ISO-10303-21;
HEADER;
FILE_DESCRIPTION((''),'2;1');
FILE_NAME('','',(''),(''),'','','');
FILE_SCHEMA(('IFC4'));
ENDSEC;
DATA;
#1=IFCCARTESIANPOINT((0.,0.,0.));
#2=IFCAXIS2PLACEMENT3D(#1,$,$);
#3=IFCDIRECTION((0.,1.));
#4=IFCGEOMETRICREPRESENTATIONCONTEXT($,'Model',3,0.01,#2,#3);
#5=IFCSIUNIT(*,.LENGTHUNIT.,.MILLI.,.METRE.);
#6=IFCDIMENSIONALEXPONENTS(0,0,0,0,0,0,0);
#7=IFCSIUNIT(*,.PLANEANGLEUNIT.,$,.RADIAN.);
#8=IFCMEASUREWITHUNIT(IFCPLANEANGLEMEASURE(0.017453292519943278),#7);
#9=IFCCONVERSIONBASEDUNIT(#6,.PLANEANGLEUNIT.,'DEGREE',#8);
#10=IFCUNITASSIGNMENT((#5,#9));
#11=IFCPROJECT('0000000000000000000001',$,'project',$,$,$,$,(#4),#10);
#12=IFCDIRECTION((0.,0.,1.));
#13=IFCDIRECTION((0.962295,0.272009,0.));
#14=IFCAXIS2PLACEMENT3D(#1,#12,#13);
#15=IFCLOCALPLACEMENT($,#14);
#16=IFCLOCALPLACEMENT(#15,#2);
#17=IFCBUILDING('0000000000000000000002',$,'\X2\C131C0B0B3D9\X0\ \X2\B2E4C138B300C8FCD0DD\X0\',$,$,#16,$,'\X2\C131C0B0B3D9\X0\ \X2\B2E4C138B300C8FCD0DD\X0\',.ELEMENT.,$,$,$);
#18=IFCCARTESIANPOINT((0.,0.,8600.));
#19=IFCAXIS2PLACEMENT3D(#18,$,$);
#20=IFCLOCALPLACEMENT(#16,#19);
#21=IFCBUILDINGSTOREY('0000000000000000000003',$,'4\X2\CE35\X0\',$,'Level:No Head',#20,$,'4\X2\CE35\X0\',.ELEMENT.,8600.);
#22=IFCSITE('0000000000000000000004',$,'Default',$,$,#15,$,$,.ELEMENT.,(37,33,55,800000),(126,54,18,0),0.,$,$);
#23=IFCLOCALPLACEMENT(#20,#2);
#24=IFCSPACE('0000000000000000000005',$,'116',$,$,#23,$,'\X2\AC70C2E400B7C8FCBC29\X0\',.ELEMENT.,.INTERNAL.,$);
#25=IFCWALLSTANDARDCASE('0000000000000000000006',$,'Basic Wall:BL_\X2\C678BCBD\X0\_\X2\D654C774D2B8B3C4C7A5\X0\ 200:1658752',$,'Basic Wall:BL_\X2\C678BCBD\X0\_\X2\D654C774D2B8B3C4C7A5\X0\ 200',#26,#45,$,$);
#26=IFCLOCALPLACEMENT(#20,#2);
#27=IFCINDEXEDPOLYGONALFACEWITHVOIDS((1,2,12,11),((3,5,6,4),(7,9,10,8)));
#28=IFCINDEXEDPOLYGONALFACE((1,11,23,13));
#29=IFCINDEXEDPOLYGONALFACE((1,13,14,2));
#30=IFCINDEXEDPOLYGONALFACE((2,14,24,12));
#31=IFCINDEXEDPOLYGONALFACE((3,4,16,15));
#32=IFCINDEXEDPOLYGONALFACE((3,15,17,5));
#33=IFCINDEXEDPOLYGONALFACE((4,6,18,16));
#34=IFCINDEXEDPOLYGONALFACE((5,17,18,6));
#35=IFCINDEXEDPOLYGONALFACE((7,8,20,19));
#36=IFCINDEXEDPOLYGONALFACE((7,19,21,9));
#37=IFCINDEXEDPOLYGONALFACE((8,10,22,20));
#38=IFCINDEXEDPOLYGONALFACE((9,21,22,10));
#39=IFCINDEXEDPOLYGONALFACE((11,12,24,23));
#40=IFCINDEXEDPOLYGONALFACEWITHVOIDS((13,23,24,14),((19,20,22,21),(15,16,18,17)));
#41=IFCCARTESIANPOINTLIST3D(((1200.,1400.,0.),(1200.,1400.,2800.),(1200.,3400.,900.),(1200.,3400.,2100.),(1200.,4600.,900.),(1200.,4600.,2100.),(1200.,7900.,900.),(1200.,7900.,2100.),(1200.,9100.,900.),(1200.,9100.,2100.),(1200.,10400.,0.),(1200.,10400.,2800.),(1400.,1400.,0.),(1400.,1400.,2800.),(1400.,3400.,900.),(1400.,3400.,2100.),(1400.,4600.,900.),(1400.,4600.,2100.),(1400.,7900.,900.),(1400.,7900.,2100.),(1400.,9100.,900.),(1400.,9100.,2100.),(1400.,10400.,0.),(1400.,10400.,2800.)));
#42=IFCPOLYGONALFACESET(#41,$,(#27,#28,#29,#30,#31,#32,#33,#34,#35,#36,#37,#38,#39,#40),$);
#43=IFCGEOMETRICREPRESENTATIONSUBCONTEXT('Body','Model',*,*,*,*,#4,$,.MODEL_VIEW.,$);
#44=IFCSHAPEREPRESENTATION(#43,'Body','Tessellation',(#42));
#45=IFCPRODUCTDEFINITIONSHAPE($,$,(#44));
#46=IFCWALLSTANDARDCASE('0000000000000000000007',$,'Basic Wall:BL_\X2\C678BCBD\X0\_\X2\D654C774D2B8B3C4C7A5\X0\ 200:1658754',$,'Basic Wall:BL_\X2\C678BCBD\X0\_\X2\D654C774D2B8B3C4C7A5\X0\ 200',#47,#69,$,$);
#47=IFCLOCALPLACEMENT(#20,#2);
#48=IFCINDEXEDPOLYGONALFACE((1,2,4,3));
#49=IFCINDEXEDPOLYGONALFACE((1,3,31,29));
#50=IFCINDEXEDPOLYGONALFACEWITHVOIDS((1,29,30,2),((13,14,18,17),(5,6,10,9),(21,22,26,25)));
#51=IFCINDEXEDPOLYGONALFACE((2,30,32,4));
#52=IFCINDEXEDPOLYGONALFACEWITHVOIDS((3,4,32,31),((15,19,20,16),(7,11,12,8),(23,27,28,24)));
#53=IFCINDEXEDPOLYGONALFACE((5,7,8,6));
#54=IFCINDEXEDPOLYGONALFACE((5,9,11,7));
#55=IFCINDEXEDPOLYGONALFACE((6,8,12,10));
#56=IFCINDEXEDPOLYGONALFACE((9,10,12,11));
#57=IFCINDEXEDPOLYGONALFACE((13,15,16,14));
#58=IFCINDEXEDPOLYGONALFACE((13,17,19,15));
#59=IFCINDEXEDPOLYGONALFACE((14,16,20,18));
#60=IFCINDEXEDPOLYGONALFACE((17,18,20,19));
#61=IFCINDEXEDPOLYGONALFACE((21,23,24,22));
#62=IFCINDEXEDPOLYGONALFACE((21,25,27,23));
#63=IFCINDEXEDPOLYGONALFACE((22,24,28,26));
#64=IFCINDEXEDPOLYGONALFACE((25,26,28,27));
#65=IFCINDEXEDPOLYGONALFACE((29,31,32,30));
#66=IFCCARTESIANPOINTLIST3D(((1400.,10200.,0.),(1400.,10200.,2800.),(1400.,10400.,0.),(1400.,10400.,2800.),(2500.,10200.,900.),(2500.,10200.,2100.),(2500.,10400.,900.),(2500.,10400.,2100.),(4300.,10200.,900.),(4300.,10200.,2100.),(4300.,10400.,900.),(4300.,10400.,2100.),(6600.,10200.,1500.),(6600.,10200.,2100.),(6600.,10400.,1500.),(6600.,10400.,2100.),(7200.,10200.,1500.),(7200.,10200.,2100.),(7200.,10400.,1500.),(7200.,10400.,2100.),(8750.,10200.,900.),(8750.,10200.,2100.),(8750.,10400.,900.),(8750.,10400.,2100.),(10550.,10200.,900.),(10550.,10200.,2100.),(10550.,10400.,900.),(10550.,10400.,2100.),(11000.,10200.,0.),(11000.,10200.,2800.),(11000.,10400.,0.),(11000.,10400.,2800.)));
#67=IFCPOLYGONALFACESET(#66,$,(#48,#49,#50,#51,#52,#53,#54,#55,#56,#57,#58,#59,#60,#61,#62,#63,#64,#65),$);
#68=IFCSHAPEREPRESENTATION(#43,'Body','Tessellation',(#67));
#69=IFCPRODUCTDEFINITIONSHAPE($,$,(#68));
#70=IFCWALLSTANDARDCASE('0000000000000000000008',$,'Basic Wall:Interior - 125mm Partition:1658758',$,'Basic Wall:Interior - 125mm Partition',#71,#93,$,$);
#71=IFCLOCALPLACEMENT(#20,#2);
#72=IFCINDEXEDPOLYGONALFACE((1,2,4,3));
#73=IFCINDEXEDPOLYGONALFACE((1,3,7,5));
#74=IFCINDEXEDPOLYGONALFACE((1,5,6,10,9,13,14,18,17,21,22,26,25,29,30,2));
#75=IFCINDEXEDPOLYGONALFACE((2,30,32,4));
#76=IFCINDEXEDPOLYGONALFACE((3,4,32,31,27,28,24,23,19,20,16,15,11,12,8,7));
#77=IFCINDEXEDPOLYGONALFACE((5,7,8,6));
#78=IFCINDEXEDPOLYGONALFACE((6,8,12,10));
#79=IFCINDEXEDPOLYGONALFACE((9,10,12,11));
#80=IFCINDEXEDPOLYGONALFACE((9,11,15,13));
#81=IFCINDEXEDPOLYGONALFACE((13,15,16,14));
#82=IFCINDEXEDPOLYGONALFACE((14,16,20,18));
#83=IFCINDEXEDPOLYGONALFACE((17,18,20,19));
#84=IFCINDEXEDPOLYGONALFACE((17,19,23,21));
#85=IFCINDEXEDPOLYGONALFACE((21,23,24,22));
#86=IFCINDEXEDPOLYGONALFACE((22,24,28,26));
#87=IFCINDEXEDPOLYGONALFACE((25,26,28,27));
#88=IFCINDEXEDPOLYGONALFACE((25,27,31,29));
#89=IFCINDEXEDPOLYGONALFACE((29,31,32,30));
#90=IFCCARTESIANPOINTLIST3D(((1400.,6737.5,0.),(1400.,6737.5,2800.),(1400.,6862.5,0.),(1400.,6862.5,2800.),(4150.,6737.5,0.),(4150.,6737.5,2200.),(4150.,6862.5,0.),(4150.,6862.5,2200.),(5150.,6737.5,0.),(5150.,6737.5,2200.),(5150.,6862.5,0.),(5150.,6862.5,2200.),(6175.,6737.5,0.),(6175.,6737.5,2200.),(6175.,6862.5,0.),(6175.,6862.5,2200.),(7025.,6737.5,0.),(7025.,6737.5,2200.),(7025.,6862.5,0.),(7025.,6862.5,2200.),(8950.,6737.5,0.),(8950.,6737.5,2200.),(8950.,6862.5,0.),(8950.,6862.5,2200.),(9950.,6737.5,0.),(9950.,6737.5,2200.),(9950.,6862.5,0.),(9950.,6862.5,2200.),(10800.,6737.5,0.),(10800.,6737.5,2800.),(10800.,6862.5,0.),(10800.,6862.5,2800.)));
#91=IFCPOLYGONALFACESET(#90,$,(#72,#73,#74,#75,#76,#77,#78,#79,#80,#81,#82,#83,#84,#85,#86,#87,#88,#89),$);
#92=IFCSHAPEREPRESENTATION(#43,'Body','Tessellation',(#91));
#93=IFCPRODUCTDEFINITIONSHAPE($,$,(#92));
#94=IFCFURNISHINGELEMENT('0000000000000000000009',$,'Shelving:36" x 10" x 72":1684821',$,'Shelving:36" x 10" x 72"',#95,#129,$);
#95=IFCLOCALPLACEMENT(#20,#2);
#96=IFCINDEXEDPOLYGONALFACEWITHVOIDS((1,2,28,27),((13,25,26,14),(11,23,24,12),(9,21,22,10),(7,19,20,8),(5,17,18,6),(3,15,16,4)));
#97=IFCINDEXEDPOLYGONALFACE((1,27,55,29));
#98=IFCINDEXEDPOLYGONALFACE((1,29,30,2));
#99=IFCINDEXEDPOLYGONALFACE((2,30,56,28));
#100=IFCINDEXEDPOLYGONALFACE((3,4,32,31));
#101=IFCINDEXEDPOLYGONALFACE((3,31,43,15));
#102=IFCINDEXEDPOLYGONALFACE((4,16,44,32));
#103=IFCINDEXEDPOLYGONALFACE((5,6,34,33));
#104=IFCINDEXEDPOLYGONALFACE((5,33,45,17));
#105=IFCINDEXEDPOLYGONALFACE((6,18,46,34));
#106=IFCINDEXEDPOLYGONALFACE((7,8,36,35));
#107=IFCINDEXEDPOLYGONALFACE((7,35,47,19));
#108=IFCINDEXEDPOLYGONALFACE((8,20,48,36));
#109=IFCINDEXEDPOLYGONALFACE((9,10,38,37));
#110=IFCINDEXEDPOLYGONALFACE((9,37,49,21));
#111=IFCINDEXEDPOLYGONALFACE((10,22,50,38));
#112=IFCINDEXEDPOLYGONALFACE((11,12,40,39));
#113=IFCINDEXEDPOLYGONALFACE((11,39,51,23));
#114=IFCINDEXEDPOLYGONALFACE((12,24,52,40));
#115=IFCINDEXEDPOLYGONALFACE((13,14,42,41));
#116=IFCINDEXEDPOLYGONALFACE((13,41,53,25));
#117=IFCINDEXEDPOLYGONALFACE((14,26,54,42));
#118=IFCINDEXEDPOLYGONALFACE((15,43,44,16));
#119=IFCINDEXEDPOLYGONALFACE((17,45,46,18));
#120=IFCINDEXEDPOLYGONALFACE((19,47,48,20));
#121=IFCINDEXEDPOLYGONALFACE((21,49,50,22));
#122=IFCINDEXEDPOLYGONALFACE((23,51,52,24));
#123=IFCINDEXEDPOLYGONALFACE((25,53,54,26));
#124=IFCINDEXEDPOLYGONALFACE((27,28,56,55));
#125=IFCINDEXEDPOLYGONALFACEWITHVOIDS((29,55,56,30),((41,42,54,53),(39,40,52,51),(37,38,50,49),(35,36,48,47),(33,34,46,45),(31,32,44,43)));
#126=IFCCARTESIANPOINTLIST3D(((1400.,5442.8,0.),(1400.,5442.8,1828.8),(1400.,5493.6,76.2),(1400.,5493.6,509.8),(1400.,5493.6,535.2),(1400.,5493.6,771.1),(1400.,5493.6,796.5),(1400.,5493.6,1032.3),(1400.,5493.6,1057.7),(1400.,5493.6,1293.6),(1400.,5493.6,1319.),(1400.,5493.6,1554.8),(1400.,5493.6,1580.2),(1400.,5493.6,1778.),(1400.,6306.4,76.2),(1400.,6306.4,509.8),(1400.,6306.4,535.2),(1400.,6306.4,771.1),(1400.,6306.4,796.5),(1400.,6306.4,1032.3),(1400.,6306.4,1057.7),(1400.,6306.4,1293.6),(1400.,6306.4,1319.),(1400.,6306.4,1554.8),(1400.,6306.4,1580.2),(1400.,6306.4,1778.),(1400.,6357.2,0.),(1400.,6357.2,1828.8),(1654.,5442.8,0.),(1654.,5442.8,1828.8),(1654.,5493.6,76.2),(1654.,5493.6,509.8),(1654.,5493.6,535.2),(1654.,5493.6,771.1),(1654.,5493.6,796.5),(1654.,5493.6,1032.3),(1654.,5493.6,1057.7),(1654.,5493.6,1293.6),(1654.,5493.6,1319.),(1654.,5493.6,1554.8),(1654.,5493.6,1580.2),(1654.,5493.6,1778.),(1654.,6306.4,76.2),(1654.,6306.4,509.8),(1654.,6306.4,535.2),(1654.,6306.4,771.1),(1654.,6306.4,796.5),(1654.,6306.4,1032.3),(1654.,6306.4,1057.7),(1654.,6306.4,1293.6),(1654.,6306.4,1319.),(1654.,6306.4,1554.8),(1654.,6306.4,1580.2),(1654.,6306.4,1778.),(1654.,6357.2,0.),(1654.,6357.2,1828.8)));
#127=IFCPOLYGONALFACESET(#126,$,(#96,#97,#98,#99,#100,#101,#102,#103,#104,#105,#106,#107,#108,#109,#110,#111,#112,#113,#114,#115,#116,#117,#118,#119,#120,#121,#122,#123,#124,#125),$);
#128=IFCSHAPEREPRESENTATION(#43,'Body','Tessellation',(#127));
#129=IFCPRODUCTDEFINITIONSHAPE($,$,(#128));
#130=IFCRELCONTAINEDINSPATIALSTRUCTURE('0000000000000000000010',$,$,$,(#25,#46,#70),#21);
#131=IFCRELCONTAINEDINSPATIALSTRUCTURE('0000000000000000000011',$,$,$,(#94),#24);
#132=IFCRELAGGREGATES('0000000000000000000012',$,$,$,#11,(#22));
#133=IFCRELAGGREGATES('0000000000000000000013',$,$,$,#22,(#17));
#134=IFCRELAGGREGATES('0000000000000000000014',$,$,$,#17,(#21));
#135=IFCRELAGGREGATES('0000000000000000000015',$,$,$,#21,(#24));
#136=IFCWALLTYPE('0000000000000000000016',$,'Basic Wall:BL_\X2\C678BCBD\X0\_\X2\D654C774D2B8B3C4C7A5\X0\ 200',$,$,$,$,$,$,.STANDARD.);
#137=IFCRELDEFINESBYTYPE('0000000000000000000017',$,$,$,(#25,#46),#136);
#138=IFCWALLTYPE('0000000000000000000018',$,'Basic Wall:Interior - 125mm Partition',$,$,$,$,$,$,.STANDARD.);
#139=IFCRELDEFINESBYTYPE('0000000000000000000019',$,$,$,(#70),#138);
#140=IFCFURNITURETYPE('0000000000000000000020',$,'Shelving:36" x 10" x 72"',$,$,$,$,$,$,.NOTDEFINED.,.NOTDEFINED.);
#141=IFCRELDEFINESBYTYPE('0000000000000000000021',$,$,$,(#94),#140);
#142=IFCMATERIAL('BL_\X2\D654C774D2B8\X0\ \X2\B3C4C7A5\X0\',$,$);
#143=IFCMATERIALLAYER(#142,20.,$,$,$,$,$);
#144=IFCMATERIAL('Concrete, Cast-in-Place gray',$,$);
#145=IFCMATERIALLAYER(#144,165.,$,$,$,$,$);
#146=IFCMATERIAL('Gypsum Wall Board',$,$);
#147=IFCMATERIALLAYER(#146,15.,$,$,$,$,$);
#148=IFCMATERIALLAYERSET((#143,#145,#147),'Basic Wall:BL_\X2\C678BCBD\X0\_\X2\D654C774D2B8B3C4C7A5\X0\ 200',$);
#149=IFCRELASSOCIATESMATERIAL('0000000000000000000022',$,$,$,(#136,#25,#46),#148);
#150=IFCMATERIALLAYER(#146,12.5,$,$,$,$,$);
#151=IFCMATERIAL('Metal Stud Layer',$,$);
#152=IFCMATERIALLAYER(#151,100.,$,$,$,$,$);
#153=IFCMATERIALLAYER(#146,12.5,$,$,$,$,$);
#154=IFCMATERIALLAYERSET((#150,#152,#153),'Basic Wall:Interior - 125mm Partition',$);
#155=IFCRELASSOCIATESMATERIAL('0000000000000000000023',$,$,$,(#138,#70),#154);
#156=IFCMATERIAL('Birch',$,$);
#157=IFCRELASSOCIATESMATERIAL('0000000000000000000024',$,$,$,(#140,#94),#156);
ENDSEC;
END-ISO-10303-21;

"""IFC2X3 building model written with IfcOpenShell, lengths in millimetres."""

from ifc_helpers import new_model, entity, si_unit, converted_unit, direction, frame, frame_2d, origin, place, context, subcontext, project, spatial, polyline, rectangle, outline, extrude, source, transform, mapped, material, layer, layer_set, layer_usage, type_object, type_shapes, element, save


model = new_model("IFC2X3")

# Units and contexts
model_context = context("Model", 3, precision=0.01, world=origin(), true_north=direction((0.0, 1.0)))
body_context = subcontext(model_context, "Body", "Model", "MODEL_VIEW")
ifc_project = project(units=[si_unit("LENGTHUNIT", "METRE", prefix="MILLI"), converted_unit("PLANEANGLEUNIT", "DEGREE", entity("IfcPlaneAngleMeasure", 0.017453292519943278), si_unit("PLANEANGLEUNIT", "RADIAN"), dimensions=[0, 0, 0, 0, 0, 0, 0])], contexts=[model_context])

# Site, building, storey
site_placement = place(None, frame((0.0, 0.0, 0.0), z_axis=(0.0, 0.0, 1.0), x_axis=(0.962295, 0.272009, 0.0)))
site = spatial("IfcSite", under=ifc_project, at=site_placement, Name="Default", CompositionType="ELEMENT", RefLatitude=(37, 33, 55, 800000), RefLongitude=(126, 54, 18, 0), RefElevation=0.0)
building_placement = place(site_placement, origin())
building = spatial("IfcBuilding", under=site, at=building_placement, Name="성산동 다세대주택", LongName="성산동 다세대주택", CompositionType="ELEMENT")
storey_placement = place(building_placement, frame((0.0, 0.0, 8600.0)))
storey = spatial("IfcBuildingStorey", under=building, at=storey_placement, Name="4층", ObjectType="Level:No Head", LongName="4층", CompositionType="ELEMENT", Elevation=8600.0)

# Walls, openings
ifc_material_1 = material(Name="BL_화이트 도장")
ifc_layer_1 = layer(ifc_material_1, 20.0)
ifc_material_2 = material(Name="Concrete, Cast-in-Place gray")
ifc_layer_2 = layer(ifc_material_2, 165.0)
ifc_material_3 = material(Name="Gypsum Wall Board")
ifc_layer_3 = layer(ifc_material_3, 15.0)
ifc_layer_set_1 = layer_set([ifc_layer_1, ifc_layer_2, ifc_layer_3], Name="Basic Wall:BL_외벽_화이트도장 200")
ifc_layer_usage_1 = layer_usage(ifc_layer_set_1, "AXIS2", "NEGATIVE", 100.0)
wall_type_1 = type_object("IfcWallType", Name="Basic Wall:BL_외벽_화이트도장 200", PredefinedType="STANDARD", material=ifc_layer_set_1)
wall_1_placement = place(storey_placement, frame((1300.0, 1400.0, 0.0), z_axis=(0.0, 0.0, 1.0), x_axis=(0.0, 1.0, 0.0)))
wall_1 = element("IfcWallStandardCase", 1, at=wall_1_placement, inside=storey, type_object=wall_type_1, material=ifc_layer_usage_1, Name="Basic Wall:BL_외벽_화이트도장 200:1658752", ObjectType="Basic Wall:BL_외벽_화이트도장 200", context=body_context, shape_type="SweptSolid", body=[
    extrude(rectangle(XDim=9000.0, YDim=200.0, at=frame_2d((4500.0, 0.0), x_axis=(-1.0, 0.0))), origin(), (0.0, 0.0, 1.0), 2800.0),
])
opening_1_placement = place(wall_1_placement, frame((2000.0, -100.0, 900.0)))
element("IfcOpeningElement", 2, at=opening_1_placement, cuts=wall_1, ObjectType="Opening", context=body_context, shape_type="SweptSolid", body=[
    extrude(rectangle(XDim=1200.0, YDim=1200.0, at=frame_2d((600.0, 600.0), x_axis=(-1.0, 0.0))), frame((0.0, 0.0, 0.0), z_axis=(0.0, 1.0, 0.0), x_axis=(0.0, 0.0, 1.0)), (0.0, 0.0, 1.0), 200.0),
])
opening_2_placement = place(wall_1_placement, frame((6500.0, -100.0, 900.0)))
element("IfcOpeningElement", 3, at=opening_2_placement, cuts=wall_1, ObjectType="Opening", context=body_context, shape_type="SweptSolid", body=[
    extrude(rectangle(XDim=1200.0, YDim=1200.0, at=frame_2d((600.0, 600.0), x_axis=(-1.0, 0.0))), frame((0.0, 0.0, 0.0), z_axis=(0.0, 1.0, 0.0), x_axis=(0.0, 0.0, 1.0)), (0.0, 0.0, 1.0), 200.0),
])
ifc_layer_usage_2 = layer_usage(ifc_layer_set_1, "AXIS2", "NEGATIVE", 100.0)
wall_2_placement = place(storey_placement, frame((1400.0, 10300.0, 0.0)))
wall_2 = element("IfcWallStandardCase", 4, at=wall_2_placement, inside=storey, type_object=wall_type_1, material=ifc_layer_usage_2, Name="Basic Wall:BL_외벽_화이트도장 200:1658754", ObjectType="Basic Wall:BL_외벽_화이트도장 200", context=body_context, shape_type="SweptSolid", body=[
    extrude(rectangle(XDim=9600.0, YDim=200.0, at=frame_2d((4800.0, 0.0), x_axis=(-1.0, 0.0))), origin(), (0.0, 0.0, 1.0), 2800.0),
])
opening_3_placement = place(wall_2_placement, frame((1100.0, -100.0, 900.0)))
element("IfcOpeningElement", 5, at=opening_3_placement, cuts=wall_2, ObjectType="Opening", context=body_context, shape_type="SweptSolid", body=[
    extrude(rectangle(XDim=1200.0, YDim=1800.0, at=frame_2d((600.0, 900.0), x_axis=(-1.0, 0.0))), frame((0.0, 0.0, 0.0), z_axis=(0.0, 1.0, 0.0), x_axis=(0.0, 0.0, 1.0)), (0.0, 0.0, 1.0), 200.0),
])
opening_4_placement = place(wall_2_placement, frame((5200.0, -100.0, 1500.0)))
element("IfcOpeningElement", 6, at=opening_4_placement, cuts=wall_2, ObjectType="Opening", context=body_context, shape_type="SweptSolid", body=[
    extrude(rectangle(XDim=600.0, YDim=600.0, at=frame_2d((300.0, 300.0), x_axis=(-1.0, 0.0))), frame((0.0, 0.0, 0.0), z_axis=(0.0, 1.0, 0.0), x_axis=(0.0, 0.0, 1.0)), (0.0, 0.0, 1.0), 200.0),
])
opening_5_placement = place(wall_2_placement, frame((7350.0, -100.0, 900.0)))
element("IfcOpeningElement", 7, at=opening_5_placement, cuts=wall_2, ObjectType="Opening", context=body_context, shape_type="SweptSolid", body=[
    extrude(rectangle(XDim=1200.0, YDim=1800.0, at=frame_2d((600.0, 900.0), x_axis=(-1.0, 0.0))), frame((0.0, 0.0, 0.0), z_axis=(0.0, 1.0, 0.0), x_axis=(0.0, 0.0, 1.0)), (0.0, 0.0, 1.0), 200.0),
])
ifc_layer_4 = layer(ifc_material_3, 12.5)
ifc_material_4 = material(Name="Metal Stud Layer")
ifc_layer_5 = layer(ifc_material_4, 100.0)
ifc_layer_6 = layer(ifc_material_3, 12.5)
ifc_layer_set_2 = layer_set([ifc_layer_4, ifc_layer_5, ifc_layer_6], Name="Basic Wall:Interior - 125mm Partition")
ifc_layer_usage_3 = layer_usage(ifc_layer_set_2, "AXIS2", "NEGATIVE", 62.5)
wall_type_2 = type_object("IfcWallType", Name="Basic Wall:Interior - 125mm Partition", PredefinedType="STANDARD", material=ifc_layer_set_2)
wall_3_placement = place(storey_placement, frame((1400.0, 6800.0, 0.0)))
wall_3 = element("IfcWallStandardCase", 8, at=wall_3_placement, inside=storey, type_object=wall_type_2, material=ifc_layer_usage_3, Name="Basic Wall:Interior - 125mm Partition:1658758", ObjectType="Basic Wall:Interior - 125mm Partition", context=body_context, shape_type="SweptSolid", body=[
    extrude(rectangle(XDim=9400.0, YDim=125.0, at=frame_2d((4700.0, 0.0), x_axis=(1.0, 0.0))), origin(), (0.0, 0.0, 1.0), 2800.0),
])
opening_6_placement = place(wall_3_placement, frame((7550.0, -62.5, 0.0)))
element("IfcOpeningElement", 9, at=opening_6_placement, cuts=wall_3, ObjectType="Opening", context=body_context, shape_type="SweptSolid", body=[
    extrude(rectangle(XDim=2200.0, YDim=1000.0, at=frame_2d((1100.0, 500.0), x_axis=(1.0, 0.0))), frame((0.0, 0.0, 0.0), z_axis=(0.0, 1.0, 0.0), x_axis=(0.0, 0.0, 1.0)), (0.0, 0.0, 1.0), 125.0),
])
opening_7_placement = place(wall_3_placement, frame((4775.0, -62.5, 0.0)))
element("IfcOpeningElement", 10, at=opening_7_placement, cuts=wall_3, ObjectType="Opening", context=body_context, shape_type="SweptSolid", body=[
    extrude(rectangle(XDim=2200.0, YDim=850.0, at=frame_2d((1100.0, 425.0), x_axis=(1.0, 0.0))), frame((0.0, 0.0, 0.0), z_axis=(0.0, 1.0, 0.0), x_axis=(0.0, 0.0, 1.0)), (0.0, 0.0, 1.0), 125.0),
])
opening_8_placement = place(wall_3_placement, frame((2750.0, -62.5, 0.0)))
element("IfcOpeningElement", 11, at=opening_8_placement, cuts=wall_3, ObjectType="Opening", context=body_context, shape_type="SweptSolid", body=[
    extrude(rectangle(XDim=2200.0, YDim=1000.0, at=frame_2d((1100.0, 500.0), x_axis=(1.0, 0.0))), frame((0.0, 0.0, 0.0), z_axis=(0.0, 1.0, 0.0), x_axis=(0.0, 0.0, 1.0)), (0.0, 0.0, 1.0), 125.0),
])

# Shared definitions
space_1_placement = place(storey_placement, origin())
space_1 = spatial("IfcSpace", under=storey, at=space_1_placement, Name="116", LongName="거실·주방", CompositionType="ELEMENT", InteriorOrExteriorSpace="INTERNAL")

# Furnishing element
ifc_material_5 = material(Name="Birch")
furniture_type_1 = type_object("IfcFurnitureType", Name="Shelving:36\" x 10\" x 72\"", AssemblyPlace="NOTDEFINED", material=ifc_material_5)
shared_shape_1 = source(origin(), body_context, "Body", "SweptSolid", [
    extrude(outline(polyline([(-457.2, -914.4), (457.2, -914.4), (457.2, 914.4), (-457.2, 914.4), (-457.2, -914.4)]), holes=[polyline([(-406.4, 863.6), (406.4, 863.6), (406.4, 665.8), (-406.4, 665.8), (-406.4, 863.6)]), polyline([(-406.4, -838.2), (-406.4, -404.6), (406.4, -404.6), (406.4, -838.2), (-406.4, -838.2)]), polyline([(406.4, 143.3), (-406.4, 143.3), (-406.4, 379.2), (406.4, 379.2), (406.4, 143.3)]), polyline([(-406.4, 640.4), (406.4, 640.4), (406.4, 404.6), (-406.4, 404.6), (-406.4, 640.4)]), polyline([(-406.4, 117.9), (406.4, 117.9), (406.4, -117.9), (-406.4, -117.9), (-406.4, 117.9)]), polyline([(-406.4, -143.3), (406.4, -143.3), (406.4, -379.2), (-406.4, -379.2), (-406.4, -143.3)])]), frame((0.0, -431.8, 914.4), z_axis=(0.0, 1.0, 0.0), x_axis=(-1.0, 0.0, 0.0)), (0.0, 0.0, 1.0), 254.0),
])
type_shapes(furniture_type_1, [shared_shape_1])
furnishing_1_placement = place(space_1_placement, frame((1222.2, 5900.0, 0.0), z_axis=(0.0, 0.0, 1.0), x_axis=(0.0, 1.0, 0.0)))
element("IfcFurnishingElement", 12, at=furnishing_1_placement, inside=space_1, type_object=furniture_type_1, material=ifc_material_5, Name="Shelving:36\" x 10\" x 72\":1684821", ObjectType="Shelving:36\" x 10\" x 72\"", context=body_context, shape_type="MappedRepresentation", body=[
    mapped(shared_shape_1, transform((0.0, 0.0, 0.0), scale=1.0)),
])

save(model, "model.ifc")
